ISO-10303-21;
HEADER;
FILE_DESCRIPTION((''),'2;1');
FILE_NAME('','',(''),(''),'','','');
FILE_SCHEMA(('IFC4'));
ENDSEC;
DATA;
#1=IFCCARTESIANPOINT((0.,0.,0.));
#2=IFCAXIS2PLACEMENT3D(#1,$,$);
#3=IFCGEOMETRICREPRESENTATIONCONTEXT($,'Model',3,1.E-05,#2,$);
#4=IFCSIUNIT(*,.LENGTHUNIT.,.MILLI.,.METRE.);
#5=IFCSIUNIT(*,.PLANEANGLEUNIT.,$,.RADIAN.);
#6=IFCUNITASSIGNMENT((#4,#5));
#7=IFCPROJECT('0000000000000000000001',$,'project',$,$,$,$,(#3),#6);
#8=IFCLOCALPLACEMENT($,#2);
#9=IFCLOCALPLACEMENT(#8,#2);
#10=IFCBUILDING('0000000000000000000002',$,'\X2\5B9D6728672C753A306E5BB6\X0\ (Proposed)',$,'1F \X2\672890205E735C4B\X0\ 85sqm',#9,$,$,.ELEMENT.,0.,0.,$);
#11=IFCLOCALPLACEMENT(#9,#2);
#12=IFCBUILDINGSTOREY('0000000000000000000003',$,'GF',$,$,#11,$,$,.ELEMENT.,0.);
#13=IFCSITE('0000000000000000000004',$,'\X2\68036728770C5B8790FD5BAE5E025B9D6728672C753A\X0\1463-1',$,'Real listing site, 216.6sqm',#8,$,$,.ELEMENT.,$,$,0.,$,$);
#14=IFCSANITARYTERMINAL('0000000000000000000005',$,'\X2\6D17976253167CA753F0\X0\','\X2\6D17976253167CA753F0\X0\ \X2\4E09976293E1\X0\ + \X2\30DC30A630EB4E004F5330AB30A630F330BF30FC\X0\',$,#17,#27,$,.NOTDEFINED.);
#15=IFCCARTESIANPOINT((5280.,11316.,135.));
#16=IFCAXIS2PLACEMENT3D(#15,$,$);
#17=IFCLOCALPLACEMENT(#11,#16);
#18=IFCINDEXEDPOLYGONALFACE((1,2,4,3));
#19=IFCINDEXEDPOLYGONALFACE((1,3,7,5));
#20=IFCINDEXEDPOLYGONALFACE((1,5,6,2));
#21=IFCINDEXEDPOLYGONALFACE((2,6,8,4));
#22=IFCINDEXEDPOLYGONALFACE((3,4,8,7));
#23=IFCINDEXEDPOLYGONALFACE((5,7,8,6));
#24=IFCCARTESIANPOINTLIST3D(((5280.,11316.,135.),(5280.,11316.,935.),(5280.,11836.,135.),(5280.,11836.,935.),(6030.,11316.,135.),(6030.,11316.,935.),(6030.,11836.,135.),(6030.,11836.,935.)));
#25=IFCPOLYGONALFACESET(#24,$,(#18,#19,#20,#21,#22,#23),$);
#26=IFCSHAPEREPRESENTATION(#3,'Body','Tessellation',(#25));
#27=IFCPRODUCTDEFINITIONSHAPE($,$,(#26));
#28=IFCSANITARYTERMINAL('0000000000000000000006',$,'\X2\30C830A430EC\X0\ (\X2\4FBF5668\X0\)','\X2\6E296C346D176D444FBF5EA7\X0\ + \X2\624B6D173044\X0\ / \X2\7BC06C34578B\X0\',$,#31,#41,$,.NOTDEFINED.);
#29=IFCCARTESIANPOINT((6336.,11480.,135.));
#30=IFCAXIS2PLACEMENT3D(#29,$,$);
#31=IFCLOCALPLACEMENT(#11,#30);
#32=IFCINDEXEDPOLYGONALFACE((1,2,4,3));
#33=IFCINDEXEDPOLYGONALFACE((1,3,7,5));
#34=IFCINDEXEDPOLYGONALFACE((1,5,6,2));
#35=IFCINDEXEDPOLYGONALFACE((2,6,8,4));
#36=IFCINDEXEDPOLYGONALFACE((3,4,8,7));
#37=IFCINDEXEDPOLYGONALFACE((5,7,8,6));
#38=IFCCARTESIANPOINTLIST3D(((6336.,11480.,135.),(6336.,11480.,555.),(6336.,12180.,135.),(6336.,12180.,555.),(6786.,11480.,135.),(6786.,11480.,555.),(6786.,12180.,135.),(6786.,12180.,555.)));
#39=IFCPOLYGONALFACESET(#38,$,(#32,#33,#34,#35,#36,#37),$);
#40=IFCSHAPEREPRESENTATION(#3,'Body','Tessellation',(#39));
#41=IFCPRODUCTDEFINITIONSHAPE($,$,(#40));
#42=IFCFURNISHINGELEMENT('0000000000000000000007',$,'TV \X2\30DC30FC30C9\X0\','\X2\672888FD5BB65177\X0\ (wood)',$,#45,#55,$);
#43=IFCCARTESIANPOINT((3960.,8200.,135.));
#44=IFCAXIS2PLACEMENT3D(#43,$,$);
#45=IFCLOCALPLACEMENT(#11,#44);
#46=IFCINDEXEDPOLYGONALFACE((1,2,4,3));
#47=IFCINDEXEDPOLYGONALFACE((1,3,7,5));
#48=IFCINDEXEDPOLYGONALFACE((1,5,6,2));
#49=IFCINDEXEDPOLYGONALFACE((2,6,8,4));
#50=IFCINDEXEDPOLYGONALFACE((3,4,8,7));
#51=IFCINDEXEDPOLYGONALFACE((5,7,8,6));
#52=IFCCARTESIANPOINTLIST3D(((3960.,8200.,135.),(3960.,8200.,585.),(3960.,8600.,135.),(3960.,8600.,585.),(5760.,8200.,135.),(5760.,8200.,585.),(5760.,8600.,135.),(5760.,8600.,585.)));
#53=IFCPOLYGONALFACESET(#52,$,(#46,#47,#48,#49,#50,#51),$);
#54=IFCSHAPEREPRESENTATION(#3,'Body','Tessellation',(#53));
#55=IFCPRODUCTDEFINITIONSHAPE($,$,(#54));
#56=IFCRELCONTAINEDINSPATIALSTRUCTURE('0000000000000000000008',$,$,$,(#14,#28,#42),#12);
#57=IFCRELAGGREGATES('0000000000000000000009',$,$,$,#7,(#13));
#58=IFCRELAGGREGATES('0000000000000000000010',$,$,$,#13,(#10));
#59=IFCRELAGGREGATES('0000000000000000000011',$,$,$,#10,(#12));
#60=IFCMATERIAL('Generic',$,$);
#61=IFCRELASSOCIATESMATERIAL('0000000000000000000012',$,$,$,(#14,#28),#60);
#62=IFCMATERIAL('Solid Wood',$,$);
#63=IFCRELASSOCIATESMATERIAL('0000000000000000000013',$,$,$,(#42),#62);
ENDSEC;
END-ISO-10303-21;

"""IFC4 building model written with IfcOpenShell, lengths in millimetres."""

from ifc_helpers import new_model, si_unit, frame, frame_2d, origin, place, context, project, spatial, rectangle, extrude, material, element, save


model = new_model("IFC4")

# Units and contexts
model_context = context("Model", 3, precision=1e-05, world=origin())
ifc_project = project(units=[si_unit("LENGTHUNIT", "METRE", prefix="MILLI"), si_unit("PLANEANGLEUNIT", "RADIAN")], contexts=[model_context])

# Site, building, storey
site_placement = place(None, origin())
site = spatial("IfcSite", under=ifc_project, at=site_placement, Name="栃木県宇都宮市宝木本町1463-1", ObjectType="Real listing site, 216.6sqm", CompositionType="ELEMENT", RefElevation=0.0)
building_placement = place(site_placement, origin())
building = spatial("IfcBuilding", under=site, at=building_placement, Name="宝木本町の家 (Proposed)", ObjectType="1F 木造平屋 85sqm", CompositionType="ELEMENT", ElevationOfRefHeight=0.0, ElevationOfTerrain=0.0)
storey_placement = place(building_placement, origin())
storey = spatial("IfcBuildingStorey", under=building, at=storey_placement, Name="GF", CompositionType="ELEMENT", Elevation=0.0)

# Shared definitions
ifc_material_1 = material(Name="Solid Wood")

# Shared definitions
ifc_material_2 = material(Name="Generic")

# Sanitary terminals
sanitary_terminal_1_placement = place(storey_placement, frame((5280.0, 11316.0, 135.0)))
element("IfcSanitaryTerminal", 1, at=sanitary_terminal_1_placement, inside=storey, material=ifc_material_2, Name="洗面化粧台", Description="洗面化粧台 三面鏡 + ボウル一体カウンター", PredefinedType="NOTDEFINED", context=model_context, shape_type="SweptSolid", body=[
    extrude(rectangle(XDim=750.0, YDim=520.0, at=frame_2d((375.0, 260.0))), frame((5280.0, 11316.0, 135.0)), (0.0, 0.0, 1.0), 800.0),
])
sanitary_terminal_2_placement = place(storey_placement, frame((6336.0, 11480.0, 135.0)))
element("IfcSanitaryTerminal", 2, at=sanitary_terminal_2_placement, inside=storey, material=ifc_material_2, Name="トイレ (便器)", Description="温水洗浄便座 + 手洗い / 節水型", PredefinedType="NOTDEFINED", context=model_context, shape_type="SweptSolid", body=[
    extrude(rectangle(XDim=450.0, YDim=700.0, at=frame_2d((225.0, 350.0))), frame((6336.0, 11480.0, 135.0)), (0.0, 0.0, 1.0), 420.0),
])

# Furnishing element
furnishing_placement = place(storey_placement, frame((3960.0, 8200.0, 135.0)))
element("IfcFurnishingElement", 3, at=furnishing_placement, inside=storey, material=ifc_material_1, Name="TV ボード", Description="木製家具 (wood)", context=model_context, shape_type="SweptSolid", body=[
    extrude(rectangle(XDim=1800.0, YDim=400.0, at=frame_2d((900.0, 200.0))), frame((3960.0, 8200.0, 135.0)), (0.0, 0.0, 1.0), 450.0),
])

save(model, "model.ifc")
